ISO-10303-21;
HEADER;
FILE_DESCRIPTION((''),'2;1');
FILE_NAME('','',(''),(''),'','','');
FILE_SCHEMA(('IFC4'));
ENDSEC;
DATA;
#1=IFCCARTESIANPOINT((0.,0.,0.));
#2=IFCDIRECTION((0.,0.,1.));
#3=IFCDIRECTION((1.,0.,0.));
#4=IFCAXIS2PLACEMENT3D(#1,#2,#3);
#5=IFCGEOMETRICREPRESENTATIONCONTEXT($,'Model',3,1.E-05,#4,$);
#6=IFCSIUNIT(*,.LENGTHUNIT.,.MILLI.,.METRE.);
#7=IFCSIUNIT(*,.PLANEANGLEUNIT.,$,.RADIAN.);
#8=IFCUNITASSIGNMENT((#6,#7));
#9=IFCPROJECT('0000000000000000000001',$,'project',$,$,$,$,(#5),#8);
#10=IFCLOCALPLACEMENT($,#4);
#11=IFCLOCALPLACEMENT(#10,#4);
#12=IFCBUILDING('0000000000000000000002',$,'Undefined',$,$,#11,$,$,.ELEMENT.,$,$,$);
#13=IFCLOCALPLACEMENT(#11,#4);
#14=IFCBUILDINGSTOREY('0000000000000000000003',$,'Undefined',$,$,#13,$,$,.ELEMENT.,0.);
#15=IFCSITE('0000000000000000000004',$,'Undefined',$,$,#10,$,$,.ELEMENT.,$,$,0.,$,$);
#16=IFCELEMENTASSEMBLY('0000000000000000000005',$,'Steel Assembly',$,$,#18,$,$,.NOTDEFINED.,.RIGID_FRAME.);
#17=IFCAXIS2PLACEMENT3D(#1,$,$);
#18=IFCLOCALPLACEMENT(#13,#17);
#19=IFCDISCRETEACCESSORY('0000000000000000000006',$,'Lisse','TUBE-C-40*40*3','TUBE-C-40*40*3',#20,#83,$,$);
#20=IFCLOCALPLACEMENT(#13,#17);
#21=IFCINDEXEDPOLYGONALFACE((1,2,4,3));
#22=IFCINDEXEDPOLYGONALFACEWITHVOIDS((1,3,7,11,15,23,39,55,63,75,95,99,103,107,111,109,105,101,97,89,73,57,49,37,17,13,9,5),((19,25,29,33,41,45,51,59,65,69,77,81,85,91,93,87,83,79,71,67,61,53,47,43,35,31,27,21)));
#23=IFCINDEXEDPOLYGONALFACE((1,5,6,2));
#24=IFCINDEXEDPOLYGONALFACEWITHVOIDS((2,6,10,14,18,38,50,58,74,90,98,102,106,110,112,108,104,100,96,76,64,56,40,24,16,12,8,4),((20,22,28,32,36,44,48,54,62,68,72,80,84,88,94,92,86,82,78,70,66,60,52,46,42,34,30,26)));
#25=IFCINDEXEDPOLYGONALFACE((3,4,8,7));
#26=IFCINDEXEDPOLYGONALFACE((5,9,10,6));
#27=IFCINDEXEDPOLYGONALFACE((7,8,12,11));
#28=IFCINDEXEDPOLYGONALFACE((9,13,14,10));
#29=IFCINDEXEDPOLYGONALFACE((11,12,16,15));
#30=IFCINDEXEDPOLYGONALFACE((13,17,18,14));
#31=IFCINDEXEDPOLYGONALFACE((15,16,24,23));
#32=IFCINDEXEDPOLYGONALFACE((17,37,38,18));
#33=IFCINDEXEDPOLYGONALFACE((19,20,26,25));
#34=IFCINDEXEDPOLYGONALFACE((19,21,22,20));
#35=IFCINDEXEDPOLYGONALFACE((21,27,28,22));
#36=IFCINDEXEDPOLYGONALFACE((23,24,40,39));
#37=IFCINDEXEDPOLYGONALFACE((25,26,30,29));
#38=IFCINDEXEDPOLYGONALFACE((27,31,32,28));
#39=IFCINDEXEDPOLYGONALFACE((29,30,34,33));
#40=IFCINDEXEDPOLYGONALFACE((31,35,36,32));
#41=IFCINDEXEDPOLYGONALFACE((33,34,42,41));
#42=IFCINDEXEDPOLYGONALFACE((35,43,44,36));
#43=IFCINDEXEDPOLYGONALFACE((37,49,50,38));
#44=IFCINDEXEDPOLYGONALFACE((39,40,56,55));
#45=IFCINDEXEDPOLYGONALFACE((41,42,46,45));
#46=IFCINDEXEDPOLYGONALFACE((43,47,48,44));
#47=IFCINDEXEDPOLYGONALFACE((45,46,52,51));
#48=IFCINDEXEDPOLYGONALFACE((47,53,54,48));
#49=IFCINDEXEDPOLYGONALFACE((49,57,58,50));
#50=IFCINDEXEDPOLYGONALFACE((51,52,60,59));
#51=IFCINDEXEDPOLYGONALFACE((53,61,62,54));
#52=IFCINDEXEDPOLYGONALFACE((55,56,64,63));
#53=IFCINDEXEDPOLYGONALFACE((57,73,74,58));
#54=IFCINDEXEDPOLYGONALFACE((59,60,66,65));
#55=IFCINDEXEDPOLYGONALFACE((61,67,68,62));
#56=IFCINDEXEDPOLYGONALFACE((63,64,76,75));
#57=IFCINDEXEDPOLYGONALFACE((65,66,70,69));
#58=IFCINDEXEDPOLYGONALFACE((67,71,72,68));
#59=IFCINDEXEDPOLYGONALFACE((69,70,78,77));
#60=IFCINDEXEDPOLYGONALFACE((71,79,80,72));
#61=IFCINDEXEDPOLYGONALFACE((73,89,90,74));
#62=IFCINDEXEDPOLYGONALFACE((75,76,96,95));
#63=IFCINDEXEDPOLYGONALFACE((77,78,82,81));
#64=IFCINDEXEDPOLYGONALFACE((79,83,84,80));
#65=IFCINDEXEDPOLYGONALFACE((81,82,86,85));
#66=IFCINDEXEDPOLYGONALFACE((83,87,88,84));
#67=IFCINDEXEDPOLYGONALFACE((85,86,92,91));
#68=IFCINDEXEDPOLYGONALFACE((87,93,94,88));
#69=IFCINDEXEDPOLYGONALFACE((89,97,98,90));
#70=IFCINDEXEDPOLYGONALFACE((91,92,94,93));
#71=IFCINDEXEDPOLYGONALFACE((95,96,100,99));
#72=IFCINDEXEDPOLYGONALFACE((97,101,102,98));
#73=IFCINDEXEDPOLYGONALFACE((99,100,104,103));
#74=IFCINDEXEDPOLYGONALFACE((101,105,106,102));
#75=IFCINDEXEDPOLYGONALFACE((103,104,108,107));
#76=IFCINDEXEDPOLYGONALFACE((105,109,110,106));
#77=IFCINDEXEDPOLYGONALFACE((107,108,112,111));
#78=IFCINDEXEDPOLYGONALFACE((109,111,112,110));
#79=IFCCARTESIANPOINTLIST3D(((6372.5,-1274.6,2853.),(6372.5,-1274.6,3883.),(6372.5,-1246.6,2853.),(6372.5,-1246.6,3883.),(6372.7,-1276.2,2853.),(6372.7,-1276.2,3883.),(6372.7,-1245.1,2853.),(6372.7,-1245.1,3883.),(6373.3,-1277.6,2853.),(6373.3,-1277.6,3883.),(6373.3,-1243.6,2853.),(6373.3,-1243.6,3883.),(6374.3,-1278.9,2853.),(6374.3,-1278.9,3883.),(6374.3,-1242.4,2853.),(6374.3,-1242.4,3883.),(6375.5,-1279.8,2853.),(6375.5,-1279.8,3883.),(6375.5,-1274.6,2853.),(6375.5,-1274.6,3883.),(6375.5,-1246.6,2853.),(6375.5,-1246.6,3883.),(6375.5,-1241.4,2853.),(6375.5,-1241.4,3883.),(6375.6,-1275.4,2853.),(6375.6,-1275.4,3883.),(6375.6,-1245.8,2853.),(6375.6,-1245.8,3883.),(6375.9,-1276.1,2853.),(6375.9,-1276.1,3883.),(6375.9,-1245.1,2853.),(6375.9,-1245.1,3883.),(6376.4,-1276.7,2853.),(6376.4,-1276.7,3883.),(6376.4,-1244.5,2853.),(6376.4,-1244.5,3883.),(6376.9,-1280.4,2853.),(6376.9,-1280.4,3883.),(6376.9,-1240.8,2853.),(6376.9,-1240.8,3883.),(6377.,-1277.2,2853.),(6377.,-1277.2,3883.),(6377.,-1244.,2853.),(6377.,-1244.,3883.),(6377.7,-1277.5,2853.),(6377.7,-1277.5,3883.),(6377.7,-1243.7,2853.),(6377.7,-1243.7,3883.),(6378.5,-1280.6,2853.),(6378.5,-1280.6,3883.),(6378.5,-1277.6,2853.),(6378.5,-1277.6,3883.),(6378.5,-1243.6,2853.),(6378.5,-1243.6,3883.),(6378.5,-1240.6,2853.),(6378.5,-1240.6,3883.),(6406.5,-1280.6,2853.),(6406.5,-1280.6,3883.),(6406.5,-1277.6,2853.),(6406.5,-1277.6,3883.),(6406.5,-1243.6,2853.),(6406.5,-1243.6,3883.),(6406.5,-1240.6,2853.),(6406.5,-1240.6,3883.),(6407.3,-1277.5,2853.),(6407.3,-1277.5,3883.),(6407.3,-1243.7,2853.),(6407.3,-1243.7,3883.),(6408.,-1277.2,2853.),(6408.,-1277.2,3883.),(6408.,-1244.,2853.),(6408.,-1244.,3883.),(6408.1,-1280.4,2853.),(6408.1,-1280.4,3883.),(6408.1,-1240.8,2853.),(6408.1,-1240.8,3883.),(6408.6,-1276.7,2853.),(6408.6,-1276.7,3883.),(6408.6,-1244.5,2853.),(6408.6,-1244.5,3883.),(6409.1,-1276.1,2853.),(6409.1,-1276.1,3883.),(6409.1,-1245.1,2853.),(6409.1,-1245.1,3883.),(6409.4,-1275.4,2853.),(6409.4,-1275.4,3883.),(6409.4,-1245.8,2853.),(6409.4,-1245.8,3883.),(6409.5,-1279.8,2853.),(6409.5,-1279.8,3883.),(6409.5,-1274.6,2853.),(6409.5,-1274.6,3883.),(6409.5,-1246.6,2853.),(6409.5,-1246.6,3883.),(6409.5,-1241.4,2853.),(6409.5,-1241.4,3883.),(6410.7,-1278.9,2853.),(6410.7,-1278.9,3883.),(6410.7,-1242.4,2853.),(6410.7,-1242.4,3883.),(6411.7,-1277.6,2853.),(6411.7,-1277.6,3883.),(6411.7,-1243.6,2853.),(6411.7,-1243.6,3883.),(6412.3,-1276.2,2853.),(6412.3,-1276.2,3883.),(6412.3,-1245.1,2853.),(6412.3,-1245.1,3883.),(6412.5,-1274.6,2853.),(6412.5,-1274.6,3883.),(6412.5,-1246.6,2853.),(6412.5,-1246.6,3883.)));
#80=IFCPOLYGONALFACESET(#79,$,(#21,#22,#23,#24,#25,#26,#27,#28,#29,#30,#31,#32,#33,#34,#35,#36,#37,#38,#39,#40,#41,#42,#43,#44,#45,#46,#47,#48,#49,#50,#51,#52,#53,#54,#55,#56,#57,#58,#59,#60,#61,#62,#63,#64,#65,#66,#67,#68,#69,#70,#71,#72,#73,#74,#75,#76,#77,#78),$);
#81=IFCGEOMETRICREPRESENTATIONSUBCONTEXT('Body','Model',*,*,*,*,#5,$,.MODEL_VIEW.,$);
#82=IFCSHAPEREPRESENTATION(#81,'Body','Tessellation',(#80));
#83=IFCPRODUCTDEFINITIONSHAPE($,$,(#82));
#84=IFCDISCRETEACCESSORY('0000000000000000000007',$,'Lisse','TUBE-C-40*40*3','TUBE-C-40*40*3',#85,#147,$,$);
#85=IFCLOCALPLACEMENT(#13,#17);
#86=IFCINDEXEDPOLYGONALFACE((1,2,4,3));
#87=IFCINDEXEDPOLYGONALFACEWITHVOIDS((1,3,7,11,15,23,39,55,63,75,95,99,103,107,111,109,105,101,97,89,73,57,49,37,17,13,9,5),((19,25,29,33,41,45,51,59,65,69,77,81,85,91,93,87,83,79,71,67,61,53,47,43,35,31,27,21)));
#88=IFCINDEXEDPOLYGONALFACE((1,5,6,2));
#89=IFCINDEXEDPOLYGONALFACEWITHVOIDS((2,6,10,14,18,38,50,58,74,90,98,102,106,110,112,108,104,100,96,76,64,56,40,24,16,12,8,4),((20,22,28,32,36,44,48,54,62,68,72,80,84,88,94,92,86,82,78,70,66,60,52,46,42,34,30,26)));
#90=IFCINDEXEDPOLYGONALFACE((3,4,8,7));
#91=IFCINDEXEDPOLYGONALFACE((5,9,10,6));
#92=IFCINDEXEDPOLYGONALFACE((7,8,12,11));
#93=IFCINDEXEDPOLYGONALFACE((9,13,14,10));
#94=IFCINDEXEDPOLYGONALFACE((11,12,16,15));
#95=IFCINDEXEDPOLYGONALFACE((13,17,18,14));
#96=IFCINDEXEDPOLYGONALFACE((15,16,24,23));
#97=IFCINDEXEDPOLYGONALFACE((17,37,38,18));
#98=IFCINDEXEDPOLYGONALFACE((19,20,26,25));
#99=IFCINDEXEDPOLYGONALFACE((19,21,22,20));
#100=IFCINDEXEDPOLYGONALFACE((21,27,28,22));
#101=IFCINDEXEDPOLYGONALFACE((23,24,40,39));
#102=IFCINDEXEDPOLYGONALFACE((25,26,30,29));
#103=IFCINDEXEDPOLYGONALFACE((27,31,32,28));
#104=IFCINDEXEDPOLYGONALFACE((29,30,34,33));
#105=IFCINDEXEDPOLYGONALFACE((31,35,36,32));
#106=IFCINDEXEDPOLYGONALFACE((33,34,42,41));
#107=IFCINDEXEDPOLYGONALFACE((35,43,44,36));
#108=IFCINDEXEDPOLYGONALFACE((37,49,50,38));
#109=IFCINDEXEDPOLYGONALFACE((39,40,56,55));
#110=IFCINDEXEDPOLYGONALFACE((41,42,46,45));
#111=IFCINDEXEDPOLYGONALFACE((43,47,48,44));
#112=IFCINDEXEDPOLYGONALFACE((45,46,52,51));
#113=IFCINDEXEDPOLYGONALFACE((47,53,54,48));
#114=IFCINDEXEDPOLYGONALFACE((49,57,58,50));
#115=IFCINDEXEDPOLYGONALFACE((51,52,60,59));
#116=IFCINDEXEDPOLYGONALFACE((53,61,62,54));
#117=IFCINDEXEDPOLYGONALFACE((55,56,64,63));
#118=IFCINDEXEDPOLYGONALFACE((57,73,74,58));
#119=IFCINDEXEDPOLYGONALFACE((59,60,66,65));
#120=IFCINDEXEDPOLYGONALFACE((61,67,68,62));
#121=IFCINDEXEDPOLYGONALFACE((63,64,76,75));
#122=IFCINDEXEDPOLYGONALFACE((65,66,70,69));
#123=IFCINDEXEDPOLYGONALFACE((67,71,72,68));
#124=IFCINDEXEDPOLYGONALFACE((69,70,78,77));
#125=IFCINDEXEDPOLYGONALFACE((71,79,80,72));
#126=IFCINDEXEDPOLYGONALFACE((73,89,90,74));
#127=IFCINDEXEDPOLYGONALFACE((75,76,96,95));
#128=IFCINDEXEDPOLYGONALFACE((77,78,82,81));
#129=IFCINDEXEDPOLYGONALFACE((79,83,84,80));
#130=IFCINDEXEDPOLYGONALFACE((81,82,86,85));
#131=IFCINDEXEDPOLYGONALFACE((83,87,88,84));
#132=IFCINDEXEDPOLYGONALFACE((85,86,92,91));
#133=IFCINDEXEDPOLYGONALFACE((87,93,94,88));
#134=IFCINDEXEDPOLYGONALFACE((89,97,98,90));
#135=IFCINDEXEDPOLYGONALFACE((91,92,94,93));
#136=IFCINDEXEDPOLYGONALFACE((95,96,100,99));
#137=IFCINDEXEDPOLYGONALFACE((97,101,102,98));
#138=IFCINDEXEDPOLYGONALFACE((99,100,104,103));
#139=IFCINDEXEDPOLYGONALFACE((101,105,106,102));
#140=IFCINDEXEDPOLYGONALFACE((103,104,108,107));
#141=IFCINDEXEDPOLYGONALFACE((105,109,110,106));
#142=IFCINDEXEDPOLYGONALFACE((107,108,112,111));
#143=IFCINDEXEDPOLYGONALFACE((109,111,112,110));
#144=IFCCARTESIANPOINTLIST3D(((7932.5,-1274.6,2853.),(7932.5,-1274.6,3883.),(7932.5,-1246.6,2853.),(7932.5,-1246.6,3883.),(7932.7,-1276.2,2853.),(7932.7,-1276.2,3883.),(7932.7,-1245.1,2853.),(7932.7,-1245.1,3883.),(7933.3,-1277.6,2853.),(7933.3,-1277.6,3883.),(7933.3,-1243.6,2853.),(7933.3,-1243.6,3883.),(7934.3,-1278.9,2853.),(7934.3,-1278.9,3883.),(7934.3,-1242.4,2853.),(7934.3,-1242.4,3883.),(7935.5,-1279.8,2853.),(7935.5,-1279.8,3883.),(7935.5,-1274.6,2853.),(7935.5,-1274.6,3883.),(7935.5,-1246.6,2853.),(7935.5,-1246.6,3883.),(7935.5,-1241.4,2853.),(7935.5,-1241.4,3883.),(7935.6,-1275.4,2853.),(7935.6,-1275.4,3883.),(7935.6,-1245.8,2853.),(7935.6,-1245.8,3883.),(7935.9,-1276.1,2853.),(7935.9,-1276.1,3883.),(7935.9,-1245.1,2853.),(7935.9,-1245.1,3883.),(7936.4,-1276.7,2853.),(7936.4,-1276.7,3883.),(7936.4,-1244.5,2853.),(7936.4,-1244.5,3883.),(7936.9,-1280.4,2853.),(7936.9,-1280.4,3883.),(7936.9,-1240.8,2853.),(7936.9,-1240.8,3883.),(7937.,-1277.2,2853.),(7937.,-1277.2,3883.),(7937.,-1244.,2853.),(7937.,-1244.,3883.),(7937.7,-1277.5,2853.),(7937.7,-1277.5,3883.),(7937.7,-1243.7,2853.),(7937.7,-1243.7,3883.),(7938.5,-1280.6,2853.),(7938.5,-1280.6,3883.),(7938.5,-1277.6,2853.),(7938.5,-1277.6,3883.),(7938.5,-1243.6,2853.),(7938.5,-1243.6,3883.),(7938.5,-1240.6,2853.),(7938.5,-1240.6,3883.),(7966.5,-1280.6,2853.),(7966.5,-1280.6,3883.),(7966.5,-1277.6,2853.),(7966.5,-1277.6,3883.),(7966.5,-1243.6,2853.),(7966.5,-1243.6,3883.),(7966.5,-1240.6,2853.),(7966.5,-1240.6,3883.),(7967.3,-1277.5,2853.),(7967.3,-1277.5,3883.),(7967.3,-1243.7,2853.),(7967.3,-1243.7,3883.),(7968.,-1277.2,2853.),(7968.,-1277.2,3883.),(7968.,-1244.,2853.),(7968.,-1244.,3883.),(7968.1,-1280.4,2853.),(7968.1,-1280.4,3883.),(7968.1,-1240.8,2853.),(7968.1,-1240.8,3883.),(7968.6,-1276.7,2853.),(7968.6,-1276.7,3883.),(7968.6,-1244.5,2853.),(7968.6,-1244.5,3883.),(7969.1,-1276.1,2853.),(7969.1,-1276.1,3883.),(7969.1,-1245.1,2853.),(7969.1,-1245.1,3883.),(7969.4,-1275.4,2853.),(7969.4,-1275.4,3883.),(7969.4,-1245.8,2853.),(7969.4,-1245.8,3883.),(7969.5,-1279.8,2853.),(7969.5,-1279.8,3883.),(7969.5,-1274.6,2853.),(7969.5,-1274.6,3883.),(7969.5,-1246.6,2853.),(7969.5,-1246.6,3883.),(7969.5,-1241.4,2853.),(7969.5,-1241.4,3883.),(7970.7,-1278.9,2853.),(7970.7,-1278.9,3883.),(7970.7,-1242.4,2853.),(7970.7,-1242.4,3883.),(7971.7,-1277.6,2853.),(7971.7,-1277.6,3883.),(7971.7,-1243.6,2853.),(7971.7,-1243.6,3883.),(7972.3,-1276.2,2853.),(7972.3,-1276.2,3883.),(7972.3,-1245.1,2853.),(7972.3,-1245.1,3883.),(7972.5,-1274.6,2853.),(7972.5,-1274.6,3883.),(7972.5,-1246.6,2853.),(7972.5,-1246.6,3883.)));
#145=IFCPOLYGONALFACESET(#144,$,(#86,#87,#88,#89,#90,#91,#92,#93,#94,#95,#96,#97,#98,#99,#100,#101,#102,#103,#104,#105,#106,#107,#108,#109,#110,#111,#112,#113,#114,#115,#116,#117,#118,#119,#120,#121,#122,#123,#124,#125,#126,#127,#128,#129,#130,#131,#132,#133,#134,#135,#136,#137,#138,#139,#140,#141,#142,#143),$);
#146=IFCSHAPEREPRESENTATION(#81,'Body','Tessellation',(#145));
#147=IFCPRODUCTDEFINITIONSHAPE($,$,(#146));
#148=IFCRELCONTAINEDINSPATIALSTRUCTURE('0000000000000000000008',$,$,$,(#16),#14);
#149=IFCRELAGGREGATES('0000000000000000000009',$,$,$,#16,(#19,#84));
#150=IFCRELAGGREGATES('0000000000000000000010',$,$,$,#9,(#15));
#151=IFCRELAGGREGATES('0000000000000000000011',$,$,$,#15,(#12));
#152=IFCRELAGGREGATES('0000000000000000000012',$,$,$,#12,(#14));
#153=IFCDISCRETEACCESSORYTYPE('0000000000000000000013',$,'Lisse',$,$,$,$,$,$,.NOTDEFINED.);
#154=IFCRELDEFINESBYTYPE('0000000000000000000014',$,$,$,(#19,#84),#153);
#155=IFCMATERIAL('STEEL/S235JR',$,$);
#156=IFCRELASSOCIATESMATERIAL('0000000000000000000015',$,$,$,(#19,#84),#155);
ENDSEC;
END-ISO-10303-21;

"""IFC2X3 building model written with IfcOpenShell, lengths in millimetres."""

from ifc_helpers import new_model, si_unit, frame, origin_with_axes, origin_2d_with_axis, place, context, subcontext, project, spatial, hollow_rectangle, extrude, material, type_object, element, aggregate, save


model = new_model("IFC2X3")

# Units and contexts
model_context = context("Model", 3, precision=1e-05, world=origin_with_axes())
body_context = subcontext(model_context, "Body", "Model", "MODEL_VIEW")
ifc_project = project(units=[si_unit("LENGTHUNIT", "METRE", prefix="MILLI"), si_unit("PLANEANGLEUNIT", "RADIAN")], contexts=[model_context])

# Site, building, storey
site_placement = place(None, origin_with_axes())
site = spatial("IfcSite", under=ifc_project, at=site_placement, Name="Undefined", CompositionType="ELEMENT", RefElevation=0.0)
building_placement = place(site_placement, origin_with_axes())
building = spatial("IfcBuilding", under=site, at=building_placement, Name="Undefined", CompositionType="ELEMENT")
storey_placement = place(building_placement, origin_with_axes())
storey = spatial("IfcBuildingStorey", under=building, at=storey_placement, Name="Undefined", CompositionType="ELEMENT", Elevation=0.0)

# Shared definitions
ifc_material_1 = material(Name="STEEL/S235JR")

# Element assembly
assembly_1_placement = place(storey_placement, origin_with_axes())
assembly_1 = element("IfcElementAssembly", 1, at=assembly_1_placement, inside=storey, Name="Steel Assembly", AssemblyPlace="NOTDEFINED", PredefinedType="RIGID_FRAME")

# Discrete accessories
discrete_accessory_type_1 = type_object("IfcDiscreteAccessoryType", Name="Lisse")
discrete_accessory_1_placement = place(assembly_1_placement, frame((6392.5, -1260.6, 3883.0), z_axis=(0.0, 1.0, 0.0), x_axis=(0.0, 0.0, -1.0)))
discrete_accessory_1 = element("IfcDiscreteAccessory", 2, at=discrete_accessory_1_placement, type_object=discrete_accessory_type_1, material=ifc_material_1, Name="Lisse", Description="TUBE-C-40*40*3", ObjectType="TUBE-C-40*40*3", context=body_context, shape_type="SweptSolid", body=[
    extrude(hollow_rectangle(XDim=40.0, YDim=40.0, WallThickness=3.0, InnerFilletRadius=3.0, OuterFilletRadius=6.0, at=origin_2d_with_axis()), frame((1030.0, 0.0, 0.0), z_axis=(-1.0, 0.0, 0.0), x_axis=(0.0, -1.0, 0.0)), (0.0, 0.0, 1.0), 1030.0),
])
discrete_accessory_2_placement = place(assembly_1_placement, frame((7952.5, -1260.6, 3883.0), z_axis=(0.0, 1.0, 0.0), x_axis=(0.0, 0.0, -1.0)))
discrete_accessory_2 = element("IfcDiscreteAccessory", 3, at=discrete_accessory_2_placement, type_object=discrete_accessory_type_1, material=ifc_material_1, Name="Lisse", Description="TUBE-C-40*40*3", ObjectType="TUBE-C-40*40*3", context=body_context, shape_type="SweptSolid", body=[
    extrude(hollow_rectangle(XDim=40.0, YDim=40.0, WallThickness=3.0, InnerFilletRadius=3.0, OuterFilletRadius=6.0, at=origin_2d_with_axis()), frame((1030.0, 0.0, 0.0), z_axis=(-1.0, 0.0, 0.0), x_axis=(0.0, -1.0, 0.0)), (0.0, 0.0, 1.0), 1030.0),
])
aggregate(assembly_1, [discrete_accessory_1, discrete_accessory_2])

save(model, "model.ifc")
